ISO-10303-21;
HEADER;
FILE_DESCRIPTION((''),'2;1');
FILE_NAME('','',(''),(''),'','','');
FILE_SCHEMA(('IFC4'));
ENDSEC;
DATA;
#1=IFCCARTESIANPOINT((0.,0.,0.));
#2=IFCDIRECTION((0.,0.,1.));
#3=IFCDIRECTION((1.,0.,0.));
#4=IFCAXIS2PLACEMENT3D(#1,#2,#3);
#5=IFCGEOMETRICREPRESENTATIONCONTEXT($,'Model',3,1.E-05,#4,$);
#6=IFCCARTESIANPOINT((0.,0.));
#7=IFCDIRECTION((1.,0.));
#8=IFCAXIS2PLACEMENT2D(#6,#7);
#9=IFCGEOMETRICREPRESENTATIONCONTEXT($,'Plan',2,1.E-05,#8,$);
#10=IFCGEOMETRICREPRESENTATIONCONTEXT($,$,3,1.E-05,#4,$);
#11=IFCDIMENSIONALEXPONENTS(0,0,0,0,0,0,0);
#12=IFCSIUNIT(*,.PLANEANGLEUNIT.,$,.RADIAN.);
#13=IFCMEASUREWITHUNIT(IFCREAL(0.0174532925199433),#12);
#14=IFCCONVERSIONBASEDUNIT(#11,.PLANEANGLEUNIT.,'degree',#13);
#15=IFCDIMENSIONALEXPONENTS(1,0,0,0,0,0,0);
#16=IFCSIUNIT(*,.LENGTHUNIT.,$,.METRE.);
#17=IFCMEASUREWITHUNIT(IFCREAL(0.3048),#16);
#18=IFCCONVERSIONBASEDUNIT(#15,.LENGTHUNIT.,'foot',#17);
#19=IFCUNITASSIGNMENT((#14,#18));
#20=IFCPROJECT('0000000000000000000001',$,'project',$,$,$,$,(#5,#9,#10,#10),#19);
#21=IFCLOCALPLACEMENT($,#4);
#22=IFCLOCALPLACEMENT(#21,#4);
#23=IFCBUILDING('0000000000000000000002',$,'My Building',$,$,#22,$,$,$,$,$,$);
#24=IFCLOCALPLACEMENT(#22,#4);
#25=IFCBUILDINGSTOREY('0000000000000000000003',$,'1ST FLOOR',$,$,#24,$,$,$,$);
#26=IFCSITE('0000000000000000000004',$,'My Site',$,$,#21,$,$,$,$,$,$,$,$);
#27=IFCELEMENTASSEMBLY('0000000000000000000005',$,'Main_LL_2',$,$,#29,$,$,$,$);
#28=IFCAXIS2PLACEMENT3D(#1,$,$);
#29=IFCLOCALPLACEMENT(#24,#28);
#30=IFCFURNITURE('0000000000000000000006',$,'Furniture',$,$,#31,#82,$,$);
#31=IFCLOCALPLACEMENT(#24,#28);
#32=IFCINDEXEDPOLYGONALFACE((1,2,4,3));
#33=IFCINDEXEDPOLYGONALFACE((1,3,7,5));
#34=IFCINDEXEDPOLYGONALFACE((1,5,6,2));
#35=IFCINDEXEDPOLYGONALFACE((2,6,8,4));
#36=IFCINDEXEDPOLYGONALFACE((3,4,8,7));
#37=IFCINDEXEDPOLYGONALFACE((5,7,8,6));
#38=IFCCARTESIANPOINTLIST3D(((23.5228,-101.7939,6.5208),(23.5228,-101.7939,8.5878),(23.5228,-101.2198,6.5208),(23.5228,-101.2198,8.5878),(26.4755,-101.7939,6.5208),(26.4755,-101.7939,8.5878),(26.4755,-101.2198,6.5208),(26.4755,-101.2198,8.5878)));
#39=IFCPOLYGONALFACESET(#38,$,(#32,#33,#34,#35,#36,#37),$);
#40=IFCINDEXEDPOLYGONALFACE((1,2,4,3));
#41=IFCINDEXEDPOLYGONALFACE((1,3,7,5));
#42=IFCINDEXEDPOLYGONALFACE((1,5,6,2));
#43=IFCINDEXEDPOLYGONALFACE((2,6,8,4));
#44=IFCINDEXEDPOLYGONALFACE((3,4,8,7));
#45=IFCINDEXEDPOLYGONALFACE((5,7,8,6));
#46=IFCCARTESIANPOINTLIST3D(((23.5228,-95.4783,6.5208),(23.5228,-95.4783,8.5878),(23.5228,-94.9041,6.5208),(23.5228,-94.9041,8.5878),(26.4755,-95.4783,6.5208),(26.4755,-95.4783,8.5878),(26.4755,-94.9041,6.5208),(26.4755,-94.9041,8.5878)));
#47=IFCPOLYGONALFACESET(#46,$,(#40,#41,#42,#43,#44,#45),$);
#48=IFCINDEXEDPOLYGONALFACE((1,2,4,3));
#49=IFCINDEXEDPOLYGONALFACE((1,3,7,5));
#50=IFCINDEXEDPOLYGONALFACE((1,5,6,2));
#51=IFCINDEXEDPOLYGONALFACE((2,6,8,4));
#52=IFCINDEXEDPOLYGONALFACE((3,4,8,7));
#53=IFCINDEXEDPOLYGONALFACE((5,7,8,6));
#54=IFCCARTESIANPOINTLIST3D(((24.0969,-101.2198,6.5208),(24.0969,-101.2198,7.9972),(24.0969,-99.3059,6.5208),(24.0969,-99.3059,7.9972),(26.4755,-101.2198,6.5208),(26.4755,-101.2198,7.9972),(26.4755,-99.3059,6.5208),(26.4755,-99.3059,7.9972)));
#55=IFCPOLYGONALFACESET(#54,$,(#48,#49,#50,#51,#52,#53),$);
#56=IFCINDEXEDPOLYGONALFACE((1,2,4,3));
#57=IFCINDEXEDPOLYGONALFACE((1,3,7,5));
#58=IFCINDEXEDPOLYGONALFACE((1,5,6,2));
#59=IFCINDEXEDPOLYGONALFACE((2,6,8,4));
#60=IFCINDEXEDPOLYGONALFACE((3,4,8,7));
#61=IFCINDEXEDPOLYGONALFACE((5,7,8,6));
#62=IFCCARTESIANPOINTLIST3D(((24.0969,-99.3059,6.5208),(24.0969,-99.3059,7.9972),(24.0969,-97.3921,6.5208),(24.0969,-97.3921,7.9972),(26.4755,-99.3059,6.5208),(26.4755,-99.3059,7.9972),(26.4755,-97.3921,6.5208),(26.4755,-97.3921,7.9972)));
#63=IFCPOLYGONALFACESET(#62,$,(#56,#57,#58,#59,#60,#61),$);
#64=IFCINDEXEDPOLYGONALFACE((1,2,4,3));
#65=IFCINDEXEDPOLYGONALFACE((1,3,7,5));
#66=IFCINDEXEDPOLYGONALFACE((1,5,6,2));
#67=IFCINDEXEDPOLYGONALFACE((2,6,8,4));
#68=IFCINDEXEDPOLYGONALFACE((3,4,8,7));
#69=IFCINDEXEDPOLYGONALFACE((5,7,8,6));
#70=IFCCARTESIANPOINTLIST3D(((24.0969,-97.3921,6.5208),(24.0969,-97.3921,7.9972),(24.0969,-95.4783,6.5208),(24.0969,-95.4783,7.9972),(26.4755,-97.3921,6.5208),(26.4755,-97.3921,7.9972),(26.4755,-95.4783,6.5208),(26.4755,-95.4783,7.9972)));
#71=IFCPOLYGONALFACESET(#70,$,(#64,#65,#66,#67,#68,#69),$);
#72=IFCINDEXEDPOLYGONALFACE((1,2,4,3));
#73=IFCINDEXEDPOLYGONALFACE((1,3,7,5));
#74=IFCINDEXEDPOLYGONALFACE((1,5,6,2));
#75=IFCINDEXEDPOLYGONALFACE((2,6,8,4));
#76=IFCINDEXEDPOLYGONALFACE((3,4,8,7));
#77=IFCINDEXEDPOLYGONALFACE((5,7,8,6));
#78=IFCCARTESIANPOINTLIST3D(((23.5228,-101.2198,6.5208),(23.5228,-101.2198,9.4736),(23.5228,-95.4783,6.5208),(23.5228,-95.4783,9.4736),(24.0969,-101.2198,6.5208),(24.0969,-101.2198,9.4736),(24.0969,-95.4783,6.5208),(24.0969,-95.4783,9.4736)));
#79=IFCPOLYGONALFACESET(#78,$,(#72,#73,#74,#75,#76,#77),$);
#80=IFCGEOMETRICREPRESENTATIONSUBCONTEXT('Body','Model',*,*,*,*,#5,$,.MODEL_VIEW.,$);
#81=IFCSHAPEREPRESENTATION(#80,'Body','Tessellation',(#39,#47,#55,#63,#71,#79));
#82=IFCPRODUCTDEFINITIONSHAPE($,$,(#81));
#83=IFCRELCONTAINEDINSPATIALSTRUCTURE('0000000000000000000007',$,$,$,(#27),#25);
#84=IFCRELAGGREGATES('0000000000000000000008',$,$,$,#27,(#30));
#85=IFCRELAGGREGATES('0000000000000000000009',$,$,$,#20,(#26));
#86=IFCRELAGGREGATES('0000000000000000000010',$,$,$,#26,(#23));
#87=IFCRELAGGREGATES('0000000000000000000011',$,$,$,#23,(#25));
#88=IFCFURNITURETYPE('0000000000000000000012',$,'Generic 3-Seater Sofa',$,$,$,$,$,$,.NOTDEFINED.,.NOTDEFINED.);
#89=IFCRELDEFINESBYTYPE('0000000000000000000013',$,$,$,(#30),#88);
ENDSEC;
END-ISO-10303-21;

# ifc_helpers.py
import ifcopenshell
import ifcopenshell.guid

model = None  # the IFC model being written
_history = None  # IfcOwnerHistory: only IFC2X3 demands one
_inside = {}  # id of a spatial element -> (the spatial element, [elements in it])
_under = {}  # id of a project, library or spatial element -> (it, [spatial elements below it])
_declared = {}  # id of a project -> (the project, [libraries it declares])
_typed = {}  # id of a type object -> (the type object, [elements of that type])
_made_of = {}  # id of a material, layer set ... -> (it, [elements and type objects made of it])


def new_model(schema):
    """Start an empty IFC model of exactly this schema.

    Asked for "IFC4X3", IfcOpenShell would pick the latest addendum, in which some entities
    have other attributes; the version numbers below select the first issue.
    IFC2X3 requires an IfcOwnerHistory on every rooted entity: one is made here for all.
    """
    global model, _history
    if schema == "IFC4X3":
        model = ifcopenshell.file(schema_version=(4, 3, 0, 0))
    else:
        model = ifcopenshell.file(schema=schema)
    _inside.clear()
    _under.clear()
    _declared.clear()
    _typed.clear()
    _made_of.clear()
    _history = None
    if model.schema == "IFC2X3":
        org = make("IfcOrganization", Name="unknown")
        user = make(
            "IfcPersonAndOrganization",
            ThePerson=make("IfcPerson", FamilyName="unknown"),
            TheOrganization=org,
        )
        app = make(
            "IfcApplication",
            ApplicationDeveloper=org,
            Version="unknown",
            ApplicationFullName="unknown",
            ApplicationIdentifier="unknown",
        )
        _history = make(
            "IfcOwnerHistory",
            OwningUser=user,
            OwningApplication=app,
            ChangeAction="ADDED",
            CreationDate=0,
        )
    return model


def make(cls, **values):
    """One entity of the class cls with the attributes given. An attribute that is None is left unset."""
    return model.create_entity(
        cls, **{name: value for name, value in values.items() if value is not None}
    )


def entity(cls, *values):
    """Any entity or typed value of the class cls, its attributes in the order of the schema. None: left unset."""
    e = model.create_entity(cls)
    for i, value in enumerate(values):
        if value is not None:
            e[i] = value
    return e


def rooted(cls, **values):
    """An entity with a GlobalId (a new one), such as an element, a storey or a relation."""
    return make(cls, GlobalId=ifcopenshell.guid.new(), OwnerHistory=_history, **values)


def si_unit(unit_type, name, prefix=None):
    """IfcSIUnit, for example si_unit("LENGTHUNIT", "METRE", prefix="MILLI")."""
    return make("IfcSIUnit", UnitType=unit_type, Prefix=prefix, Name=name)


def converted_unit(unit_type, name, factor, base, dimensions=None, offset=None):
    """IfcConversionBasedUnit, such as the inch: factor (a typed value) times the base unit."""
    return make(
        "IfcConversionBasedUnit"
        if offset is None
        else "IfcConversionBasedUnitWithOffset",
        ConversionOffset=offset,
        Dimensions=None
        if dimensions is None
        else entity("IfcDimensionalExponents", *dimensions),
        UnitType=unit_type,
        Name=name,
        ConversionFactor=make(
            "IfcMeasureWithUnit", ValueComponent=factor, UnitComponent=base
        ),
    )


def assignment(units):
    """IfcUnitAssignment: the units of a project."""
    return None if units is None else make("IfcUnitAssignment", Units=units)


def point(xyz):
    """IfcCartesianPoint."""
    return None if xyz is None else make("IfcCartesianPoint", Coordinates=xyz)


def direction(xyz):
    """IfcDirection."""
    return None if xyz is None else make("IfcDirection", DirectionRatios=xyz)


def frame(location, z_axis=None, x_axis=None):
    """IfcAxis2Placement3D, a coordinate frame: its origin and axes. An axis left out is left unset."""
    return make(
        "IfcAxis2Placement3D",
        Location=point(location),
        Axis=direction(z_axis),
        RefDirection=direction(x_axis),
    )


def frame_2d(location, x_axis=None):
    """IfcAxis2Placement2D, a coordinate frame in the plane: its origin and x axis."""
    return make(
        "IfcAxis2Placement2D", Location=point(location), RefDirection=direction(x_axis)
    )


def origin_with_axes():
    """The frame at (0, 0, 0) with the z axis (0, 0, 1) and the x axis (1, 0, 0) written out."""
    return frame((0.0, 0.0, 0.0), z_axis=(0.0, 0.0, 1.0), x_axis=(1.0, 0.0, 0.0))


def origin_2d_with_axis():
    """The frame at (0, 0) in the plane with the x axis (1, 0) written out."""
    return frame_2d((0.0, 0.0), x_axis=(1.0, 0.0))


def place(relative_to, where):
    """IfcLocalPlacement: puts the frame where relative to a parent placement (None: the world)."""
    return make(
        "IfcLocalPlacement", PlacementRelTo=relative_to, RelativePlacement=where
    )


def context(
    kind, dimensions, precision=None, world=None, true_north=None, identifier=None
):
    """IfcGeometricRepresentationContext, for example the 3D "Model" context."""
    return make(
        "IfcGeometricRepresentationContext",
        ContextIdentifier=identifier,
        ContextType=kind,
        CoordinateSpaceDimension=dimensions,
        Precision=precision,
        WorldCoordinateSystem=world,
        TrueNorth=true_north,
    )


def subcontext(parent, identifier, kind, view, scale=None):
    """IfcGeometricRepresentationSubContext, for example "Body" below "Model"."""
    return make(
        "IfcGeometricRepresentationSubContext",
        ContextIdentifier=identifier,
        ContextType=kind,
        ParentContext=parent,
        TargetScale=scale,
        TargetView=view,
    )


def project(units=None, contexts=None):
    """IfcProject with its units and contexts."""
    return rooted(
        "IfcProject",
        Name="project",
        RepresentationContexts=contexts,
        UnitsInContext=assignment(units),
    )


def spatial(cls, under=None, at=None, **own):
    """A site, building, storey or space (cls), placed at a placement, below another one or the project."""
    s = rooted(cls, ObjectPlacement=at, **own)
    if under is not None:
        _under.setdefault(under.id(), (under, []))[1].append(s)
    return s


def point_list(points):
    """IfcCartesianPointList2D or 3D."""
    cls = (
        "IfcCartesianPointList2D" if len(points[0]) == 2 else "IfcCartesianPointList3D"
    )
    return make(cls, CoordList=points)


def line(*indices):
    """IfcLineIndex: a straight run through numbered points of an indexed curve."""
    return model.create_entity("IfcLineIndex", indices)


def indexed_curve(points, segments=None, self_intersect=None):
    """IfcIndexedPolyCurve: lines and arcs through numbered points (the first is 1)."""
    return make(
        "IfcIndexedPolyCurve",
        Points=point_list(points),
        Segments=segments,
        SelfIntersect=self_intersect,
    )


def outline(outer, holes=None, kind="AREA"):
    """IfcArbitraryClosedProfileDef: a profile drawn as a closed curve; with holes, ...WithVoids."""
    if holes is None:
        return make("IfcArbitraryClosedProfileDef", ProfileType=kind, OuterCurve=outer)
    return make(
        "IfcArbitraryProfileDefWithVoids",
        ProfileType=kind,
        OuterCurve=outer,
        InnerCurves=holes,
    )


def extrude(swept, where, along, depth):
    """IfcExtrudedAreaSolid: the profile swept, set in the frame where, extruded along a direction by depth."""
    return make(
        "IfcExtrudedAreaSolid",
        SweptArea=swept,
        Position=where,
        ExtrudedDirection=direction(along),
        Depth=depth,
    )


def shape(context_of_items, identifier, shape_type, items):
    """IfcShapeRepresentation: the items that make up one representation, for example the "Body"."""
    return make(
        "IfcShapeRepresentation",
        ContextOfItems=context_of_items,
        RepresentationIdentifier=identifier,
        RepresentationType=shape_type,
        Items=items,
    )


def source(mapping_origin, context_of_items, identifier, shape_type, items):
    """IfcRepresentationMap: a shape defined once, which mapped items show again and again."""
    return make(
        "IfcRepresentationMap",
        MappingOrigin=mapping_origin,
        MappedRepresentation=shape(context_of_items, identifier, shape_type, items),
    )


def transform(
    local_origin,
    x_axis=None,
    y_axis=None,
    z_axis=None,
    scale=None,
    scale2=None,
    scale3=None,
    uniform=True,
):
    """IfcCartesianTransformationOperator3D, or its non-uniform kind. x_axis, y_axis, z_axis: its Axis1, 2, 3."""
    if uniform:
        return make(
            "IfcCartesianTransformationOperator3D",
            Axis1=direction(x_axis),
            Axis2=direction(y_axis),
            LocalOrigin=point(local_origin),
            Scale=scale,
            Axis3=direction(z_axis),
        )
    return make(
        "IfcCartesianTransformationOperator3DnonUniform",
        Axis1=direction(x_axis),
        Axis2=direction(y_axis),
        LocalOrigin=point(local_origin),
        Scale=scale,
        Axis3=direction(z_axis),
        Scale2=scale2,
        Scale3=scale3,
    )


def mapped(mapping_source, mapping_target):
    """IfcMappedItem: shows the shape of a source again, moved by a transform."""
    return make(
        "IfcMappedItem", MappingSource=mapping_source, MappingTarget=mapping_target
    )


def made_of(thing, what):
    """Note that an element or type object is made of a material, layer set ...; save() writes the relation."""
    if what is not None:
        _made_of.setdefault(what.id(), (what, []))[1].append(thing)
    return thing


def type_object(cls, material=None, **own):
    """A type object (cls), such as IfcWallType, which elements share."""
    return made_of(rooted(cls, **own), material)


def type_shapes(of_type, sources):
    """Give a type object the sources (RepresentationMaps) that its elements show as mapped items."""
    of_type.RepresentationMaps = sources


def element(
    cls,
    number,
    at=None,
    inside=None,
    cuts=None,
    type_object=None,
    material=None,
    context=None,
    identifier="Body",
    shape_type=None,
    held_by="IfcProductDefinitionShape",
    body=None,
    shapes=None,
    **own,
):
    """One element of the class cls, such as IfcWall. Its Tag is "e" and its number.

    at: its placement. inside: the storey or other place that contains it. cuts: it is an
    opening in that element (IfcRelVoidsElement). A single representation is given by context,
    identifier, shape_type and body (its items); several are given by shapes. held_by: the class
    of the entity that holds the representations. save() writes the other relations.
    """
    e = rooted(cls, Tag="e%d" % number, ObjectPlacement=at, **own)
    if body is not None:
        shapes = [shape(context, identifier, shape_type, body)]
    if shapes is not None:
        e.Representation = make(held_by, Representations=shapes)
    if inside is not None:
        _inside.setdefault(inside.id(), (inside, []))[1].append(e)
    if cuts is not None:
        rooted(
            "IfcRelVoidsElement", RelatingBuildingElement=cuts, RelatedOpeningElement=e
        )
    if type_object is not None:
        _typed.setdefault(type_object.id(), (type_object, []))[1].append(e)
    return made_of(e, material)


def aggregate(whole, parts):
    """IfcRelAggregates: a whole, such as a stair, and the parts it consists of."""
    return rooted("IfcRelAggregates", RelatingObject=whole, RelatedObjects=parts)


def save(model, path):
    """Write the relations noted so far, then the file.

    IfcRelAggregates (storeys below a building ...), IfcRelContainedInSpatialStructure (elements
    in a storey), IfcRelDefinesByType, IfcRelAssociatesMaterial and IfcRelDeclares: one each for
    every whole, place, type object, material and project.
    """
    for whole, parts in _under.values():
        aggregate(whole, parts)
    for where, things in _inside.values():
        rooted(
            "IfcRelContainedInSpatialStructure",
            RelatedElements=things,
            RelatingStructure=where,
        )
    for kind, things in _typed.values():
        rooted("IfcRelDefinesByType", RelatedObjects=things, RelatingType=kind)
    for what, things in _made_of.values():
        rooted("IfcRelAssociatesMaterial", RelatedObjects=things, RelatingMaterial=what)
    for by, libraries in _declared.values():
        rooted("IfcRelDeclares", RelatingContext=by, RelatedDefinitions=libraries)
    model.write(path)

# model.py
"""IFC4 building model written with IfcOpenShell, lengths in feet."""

from ifc_helpers import new_model, entity, si_unit, converted_unit, frame, origin_with_axes, origin_2d_with_axis, place, context, subcontext, project, spatial, line, indexed_curve, outline, extrude, source, transform, mapped, type_object, type_shapes, element, aggregate, save


model = new_model("IFC4")

# Units and contexts
model_context = context("Model", 3, precision=1e-05, world=origin_with_axes())
plan_context = context("Plan", 2, precision=1e-05, world=origin_2d_with_axis())
context_of_model = context(None, 3, precision=1e-05, world=origin_with_axes())
body_context = subcontext(model_context, "Body", "Model", "MODEL_VIEW")
ifc_project = project(units=[converted_unit("PLANEANGLEUNIT", "degree", entity("IfcReal", 0.0174532925199433), si_unit("PLANEANGLEUNIT", "RADIAN"), dimensions=[0, 0, 0, 0, 0, 0, 0]), converted_unit("LENGTHUNIT", "foot", entity("IfcReal", 0.3048), si_unit("LENGTHUNIT", "METRE"), dimensions=[1, 0, 0, 0, 0, 0, 0])], contexts=[model_context, plan_context, context_of_model, context_of_model])

# Site, building, storey
site_placement = place(None, origin_with_axes())
site = spatial("IfcSite", under=ifc_project, at=site_placement, Name="My Site")
building_placement = place(site_placement, origin_with_axes())
building = spatial("IfcBuilding", under=site, at=building_placement, Name="My Building")
storey_placement = place(building_placement, origin_with_axes())
storey = spatial("IfcBuildingStorey", under=building, at=storey_placement, Name="1ST FLOOR")

# Element assembly, furniture
assembly_placement = place(storey_placement, frame((-23.2742, 368.5498, 6.5), z_axis=(0.0, 0.0, 1.0), x_axis=(1.0, 0.0, 0.0)))
assembly = element("IfcElementAssembly", 1, at=assembly_placement, inside=storey, Name="Main_LL_2")
furniture_type = type_object("IfcFurnitureType", Name="Generic 3-Seater Sofa", AssemblyPlace="NOTDEFINED", PredefinedType="NOTDEFINED")
shared_shape_1 = source(origin_with_axes(), body_context, "Body", "SweptSolid", [
    extrude(outline(indexed_curve([(0.0, 0.0), (0.5741, 0.0), (0.5741, 2.9528), (0.0, 2.9528)], segments=[line(1, 2), line(2, 3), line(3, 4), line(4, 1)])), frame((-3.4449, -2.9528, 0.0), z_axis=(0.0, 0.0, 1.0), x_axis=(1.0, 0.0, 0.0)), (0.0, 0.0, 1.0), 2.0669),
    extrude(outline(indexed_curve([(0.0, 0.0), (0.5741, 0.0), (0.5741, 2.9528), (0.0, 2.9528)], segments=[line(1, 2), line(2, 3), line(3, 4), line(4, 1)])), frame((2.8707, -2.9528, 0.0), z_axis=(0.0, 0.0, 1.0), x_axis=(1.0, 0.0, 0.0)), (0.0, 0.0, 1.0), 2.0669),
    extrude(outline(indexed_curve([(0.5741, 0.0), (2.488, 0.0), (2.488, 2.3786), (0.5741, 2.3786)], segments=[line(1, 2), line(2, 3), line(3, 4), line(4, 1)])), frame((-3.4449, -2.9528, 0.0), z_axis=(0.0, 0.0, 1.0), x_axis=(1.0, 0.0, 0.0)), (0.0, 0.0, 1.0), 1.4764),
    extrude(outline(indexed_curve([(2.488, 0.0), (4.4018, 0.0), (4.4018, 2.3786), (2.488, 2.3786)], segments=[line(1, 2), line(2, 3), line(3, 4), line(4, 1)])), frame((-3.4449, -2.9528, 0.0), z_axis=(0.0, 0.0, 1.0), x_axis=(1.0, 0.0, 0.0)), (0.0, 0.0, 1.0), 1.4764),
    extrude(outline(indexed_curve([(4.4018, 0.0), (6.3156, 0.0), (6.3156, 2.3786), (4.4018, 2.3786)], segments=[line(1, 2), line(2, 3), line(3, 4), line(4, 1)])), frame((-3.4449, -2.9528, 0.0), z_axis=(0.0, 0.0, 1.0), x_axis=(1.0, 0.0, 0.0)), (0.0, 0.0, 1.0), 1.4764),
    extrude(outline(indexed_curve([(0.5741, 2.3786), (6.3156, 2.3786), (6.3156, 2.9528), (0.5741, 2.9528)], segments=[line(1, 2), line(2, 3), line(3, 4), line(4, 1)])), frame((-3.4449, -2.9528, 0.0), z_axis=(0.0, 0.0, 1.0), x_axis=(1.0, 0.0, 0.0)), (0.0, 0.0, 1.0), 2.9528),
])
type_shapes(furniture_type, [shared_shape_1])
furniture_placement = place(assembly_placement, frame((46.7969, -466.8989, 0.0208), z_axis=(0.0, 0.0, 1.0), x_axis=(0.0, 1.0, 0.0)))
furniture = element("IfcFurniture", 2, at=furniture_placement, type_object=furniture_type, Name="Furniture", context=body_context, shape_type="MappedRepresentation", body=[
    mapped(shared_shape_1, transform((0.0, 0.0, 0.0), x_axis=(1.0, 0.0, 0.0), y_axis=(0.0, 1.0, 0.0), z_axis=(0.0, 0.0, 1.0), scale=1.0)),
])
aggregate(assembly, [furniture])

save(model, "model.ifc")
